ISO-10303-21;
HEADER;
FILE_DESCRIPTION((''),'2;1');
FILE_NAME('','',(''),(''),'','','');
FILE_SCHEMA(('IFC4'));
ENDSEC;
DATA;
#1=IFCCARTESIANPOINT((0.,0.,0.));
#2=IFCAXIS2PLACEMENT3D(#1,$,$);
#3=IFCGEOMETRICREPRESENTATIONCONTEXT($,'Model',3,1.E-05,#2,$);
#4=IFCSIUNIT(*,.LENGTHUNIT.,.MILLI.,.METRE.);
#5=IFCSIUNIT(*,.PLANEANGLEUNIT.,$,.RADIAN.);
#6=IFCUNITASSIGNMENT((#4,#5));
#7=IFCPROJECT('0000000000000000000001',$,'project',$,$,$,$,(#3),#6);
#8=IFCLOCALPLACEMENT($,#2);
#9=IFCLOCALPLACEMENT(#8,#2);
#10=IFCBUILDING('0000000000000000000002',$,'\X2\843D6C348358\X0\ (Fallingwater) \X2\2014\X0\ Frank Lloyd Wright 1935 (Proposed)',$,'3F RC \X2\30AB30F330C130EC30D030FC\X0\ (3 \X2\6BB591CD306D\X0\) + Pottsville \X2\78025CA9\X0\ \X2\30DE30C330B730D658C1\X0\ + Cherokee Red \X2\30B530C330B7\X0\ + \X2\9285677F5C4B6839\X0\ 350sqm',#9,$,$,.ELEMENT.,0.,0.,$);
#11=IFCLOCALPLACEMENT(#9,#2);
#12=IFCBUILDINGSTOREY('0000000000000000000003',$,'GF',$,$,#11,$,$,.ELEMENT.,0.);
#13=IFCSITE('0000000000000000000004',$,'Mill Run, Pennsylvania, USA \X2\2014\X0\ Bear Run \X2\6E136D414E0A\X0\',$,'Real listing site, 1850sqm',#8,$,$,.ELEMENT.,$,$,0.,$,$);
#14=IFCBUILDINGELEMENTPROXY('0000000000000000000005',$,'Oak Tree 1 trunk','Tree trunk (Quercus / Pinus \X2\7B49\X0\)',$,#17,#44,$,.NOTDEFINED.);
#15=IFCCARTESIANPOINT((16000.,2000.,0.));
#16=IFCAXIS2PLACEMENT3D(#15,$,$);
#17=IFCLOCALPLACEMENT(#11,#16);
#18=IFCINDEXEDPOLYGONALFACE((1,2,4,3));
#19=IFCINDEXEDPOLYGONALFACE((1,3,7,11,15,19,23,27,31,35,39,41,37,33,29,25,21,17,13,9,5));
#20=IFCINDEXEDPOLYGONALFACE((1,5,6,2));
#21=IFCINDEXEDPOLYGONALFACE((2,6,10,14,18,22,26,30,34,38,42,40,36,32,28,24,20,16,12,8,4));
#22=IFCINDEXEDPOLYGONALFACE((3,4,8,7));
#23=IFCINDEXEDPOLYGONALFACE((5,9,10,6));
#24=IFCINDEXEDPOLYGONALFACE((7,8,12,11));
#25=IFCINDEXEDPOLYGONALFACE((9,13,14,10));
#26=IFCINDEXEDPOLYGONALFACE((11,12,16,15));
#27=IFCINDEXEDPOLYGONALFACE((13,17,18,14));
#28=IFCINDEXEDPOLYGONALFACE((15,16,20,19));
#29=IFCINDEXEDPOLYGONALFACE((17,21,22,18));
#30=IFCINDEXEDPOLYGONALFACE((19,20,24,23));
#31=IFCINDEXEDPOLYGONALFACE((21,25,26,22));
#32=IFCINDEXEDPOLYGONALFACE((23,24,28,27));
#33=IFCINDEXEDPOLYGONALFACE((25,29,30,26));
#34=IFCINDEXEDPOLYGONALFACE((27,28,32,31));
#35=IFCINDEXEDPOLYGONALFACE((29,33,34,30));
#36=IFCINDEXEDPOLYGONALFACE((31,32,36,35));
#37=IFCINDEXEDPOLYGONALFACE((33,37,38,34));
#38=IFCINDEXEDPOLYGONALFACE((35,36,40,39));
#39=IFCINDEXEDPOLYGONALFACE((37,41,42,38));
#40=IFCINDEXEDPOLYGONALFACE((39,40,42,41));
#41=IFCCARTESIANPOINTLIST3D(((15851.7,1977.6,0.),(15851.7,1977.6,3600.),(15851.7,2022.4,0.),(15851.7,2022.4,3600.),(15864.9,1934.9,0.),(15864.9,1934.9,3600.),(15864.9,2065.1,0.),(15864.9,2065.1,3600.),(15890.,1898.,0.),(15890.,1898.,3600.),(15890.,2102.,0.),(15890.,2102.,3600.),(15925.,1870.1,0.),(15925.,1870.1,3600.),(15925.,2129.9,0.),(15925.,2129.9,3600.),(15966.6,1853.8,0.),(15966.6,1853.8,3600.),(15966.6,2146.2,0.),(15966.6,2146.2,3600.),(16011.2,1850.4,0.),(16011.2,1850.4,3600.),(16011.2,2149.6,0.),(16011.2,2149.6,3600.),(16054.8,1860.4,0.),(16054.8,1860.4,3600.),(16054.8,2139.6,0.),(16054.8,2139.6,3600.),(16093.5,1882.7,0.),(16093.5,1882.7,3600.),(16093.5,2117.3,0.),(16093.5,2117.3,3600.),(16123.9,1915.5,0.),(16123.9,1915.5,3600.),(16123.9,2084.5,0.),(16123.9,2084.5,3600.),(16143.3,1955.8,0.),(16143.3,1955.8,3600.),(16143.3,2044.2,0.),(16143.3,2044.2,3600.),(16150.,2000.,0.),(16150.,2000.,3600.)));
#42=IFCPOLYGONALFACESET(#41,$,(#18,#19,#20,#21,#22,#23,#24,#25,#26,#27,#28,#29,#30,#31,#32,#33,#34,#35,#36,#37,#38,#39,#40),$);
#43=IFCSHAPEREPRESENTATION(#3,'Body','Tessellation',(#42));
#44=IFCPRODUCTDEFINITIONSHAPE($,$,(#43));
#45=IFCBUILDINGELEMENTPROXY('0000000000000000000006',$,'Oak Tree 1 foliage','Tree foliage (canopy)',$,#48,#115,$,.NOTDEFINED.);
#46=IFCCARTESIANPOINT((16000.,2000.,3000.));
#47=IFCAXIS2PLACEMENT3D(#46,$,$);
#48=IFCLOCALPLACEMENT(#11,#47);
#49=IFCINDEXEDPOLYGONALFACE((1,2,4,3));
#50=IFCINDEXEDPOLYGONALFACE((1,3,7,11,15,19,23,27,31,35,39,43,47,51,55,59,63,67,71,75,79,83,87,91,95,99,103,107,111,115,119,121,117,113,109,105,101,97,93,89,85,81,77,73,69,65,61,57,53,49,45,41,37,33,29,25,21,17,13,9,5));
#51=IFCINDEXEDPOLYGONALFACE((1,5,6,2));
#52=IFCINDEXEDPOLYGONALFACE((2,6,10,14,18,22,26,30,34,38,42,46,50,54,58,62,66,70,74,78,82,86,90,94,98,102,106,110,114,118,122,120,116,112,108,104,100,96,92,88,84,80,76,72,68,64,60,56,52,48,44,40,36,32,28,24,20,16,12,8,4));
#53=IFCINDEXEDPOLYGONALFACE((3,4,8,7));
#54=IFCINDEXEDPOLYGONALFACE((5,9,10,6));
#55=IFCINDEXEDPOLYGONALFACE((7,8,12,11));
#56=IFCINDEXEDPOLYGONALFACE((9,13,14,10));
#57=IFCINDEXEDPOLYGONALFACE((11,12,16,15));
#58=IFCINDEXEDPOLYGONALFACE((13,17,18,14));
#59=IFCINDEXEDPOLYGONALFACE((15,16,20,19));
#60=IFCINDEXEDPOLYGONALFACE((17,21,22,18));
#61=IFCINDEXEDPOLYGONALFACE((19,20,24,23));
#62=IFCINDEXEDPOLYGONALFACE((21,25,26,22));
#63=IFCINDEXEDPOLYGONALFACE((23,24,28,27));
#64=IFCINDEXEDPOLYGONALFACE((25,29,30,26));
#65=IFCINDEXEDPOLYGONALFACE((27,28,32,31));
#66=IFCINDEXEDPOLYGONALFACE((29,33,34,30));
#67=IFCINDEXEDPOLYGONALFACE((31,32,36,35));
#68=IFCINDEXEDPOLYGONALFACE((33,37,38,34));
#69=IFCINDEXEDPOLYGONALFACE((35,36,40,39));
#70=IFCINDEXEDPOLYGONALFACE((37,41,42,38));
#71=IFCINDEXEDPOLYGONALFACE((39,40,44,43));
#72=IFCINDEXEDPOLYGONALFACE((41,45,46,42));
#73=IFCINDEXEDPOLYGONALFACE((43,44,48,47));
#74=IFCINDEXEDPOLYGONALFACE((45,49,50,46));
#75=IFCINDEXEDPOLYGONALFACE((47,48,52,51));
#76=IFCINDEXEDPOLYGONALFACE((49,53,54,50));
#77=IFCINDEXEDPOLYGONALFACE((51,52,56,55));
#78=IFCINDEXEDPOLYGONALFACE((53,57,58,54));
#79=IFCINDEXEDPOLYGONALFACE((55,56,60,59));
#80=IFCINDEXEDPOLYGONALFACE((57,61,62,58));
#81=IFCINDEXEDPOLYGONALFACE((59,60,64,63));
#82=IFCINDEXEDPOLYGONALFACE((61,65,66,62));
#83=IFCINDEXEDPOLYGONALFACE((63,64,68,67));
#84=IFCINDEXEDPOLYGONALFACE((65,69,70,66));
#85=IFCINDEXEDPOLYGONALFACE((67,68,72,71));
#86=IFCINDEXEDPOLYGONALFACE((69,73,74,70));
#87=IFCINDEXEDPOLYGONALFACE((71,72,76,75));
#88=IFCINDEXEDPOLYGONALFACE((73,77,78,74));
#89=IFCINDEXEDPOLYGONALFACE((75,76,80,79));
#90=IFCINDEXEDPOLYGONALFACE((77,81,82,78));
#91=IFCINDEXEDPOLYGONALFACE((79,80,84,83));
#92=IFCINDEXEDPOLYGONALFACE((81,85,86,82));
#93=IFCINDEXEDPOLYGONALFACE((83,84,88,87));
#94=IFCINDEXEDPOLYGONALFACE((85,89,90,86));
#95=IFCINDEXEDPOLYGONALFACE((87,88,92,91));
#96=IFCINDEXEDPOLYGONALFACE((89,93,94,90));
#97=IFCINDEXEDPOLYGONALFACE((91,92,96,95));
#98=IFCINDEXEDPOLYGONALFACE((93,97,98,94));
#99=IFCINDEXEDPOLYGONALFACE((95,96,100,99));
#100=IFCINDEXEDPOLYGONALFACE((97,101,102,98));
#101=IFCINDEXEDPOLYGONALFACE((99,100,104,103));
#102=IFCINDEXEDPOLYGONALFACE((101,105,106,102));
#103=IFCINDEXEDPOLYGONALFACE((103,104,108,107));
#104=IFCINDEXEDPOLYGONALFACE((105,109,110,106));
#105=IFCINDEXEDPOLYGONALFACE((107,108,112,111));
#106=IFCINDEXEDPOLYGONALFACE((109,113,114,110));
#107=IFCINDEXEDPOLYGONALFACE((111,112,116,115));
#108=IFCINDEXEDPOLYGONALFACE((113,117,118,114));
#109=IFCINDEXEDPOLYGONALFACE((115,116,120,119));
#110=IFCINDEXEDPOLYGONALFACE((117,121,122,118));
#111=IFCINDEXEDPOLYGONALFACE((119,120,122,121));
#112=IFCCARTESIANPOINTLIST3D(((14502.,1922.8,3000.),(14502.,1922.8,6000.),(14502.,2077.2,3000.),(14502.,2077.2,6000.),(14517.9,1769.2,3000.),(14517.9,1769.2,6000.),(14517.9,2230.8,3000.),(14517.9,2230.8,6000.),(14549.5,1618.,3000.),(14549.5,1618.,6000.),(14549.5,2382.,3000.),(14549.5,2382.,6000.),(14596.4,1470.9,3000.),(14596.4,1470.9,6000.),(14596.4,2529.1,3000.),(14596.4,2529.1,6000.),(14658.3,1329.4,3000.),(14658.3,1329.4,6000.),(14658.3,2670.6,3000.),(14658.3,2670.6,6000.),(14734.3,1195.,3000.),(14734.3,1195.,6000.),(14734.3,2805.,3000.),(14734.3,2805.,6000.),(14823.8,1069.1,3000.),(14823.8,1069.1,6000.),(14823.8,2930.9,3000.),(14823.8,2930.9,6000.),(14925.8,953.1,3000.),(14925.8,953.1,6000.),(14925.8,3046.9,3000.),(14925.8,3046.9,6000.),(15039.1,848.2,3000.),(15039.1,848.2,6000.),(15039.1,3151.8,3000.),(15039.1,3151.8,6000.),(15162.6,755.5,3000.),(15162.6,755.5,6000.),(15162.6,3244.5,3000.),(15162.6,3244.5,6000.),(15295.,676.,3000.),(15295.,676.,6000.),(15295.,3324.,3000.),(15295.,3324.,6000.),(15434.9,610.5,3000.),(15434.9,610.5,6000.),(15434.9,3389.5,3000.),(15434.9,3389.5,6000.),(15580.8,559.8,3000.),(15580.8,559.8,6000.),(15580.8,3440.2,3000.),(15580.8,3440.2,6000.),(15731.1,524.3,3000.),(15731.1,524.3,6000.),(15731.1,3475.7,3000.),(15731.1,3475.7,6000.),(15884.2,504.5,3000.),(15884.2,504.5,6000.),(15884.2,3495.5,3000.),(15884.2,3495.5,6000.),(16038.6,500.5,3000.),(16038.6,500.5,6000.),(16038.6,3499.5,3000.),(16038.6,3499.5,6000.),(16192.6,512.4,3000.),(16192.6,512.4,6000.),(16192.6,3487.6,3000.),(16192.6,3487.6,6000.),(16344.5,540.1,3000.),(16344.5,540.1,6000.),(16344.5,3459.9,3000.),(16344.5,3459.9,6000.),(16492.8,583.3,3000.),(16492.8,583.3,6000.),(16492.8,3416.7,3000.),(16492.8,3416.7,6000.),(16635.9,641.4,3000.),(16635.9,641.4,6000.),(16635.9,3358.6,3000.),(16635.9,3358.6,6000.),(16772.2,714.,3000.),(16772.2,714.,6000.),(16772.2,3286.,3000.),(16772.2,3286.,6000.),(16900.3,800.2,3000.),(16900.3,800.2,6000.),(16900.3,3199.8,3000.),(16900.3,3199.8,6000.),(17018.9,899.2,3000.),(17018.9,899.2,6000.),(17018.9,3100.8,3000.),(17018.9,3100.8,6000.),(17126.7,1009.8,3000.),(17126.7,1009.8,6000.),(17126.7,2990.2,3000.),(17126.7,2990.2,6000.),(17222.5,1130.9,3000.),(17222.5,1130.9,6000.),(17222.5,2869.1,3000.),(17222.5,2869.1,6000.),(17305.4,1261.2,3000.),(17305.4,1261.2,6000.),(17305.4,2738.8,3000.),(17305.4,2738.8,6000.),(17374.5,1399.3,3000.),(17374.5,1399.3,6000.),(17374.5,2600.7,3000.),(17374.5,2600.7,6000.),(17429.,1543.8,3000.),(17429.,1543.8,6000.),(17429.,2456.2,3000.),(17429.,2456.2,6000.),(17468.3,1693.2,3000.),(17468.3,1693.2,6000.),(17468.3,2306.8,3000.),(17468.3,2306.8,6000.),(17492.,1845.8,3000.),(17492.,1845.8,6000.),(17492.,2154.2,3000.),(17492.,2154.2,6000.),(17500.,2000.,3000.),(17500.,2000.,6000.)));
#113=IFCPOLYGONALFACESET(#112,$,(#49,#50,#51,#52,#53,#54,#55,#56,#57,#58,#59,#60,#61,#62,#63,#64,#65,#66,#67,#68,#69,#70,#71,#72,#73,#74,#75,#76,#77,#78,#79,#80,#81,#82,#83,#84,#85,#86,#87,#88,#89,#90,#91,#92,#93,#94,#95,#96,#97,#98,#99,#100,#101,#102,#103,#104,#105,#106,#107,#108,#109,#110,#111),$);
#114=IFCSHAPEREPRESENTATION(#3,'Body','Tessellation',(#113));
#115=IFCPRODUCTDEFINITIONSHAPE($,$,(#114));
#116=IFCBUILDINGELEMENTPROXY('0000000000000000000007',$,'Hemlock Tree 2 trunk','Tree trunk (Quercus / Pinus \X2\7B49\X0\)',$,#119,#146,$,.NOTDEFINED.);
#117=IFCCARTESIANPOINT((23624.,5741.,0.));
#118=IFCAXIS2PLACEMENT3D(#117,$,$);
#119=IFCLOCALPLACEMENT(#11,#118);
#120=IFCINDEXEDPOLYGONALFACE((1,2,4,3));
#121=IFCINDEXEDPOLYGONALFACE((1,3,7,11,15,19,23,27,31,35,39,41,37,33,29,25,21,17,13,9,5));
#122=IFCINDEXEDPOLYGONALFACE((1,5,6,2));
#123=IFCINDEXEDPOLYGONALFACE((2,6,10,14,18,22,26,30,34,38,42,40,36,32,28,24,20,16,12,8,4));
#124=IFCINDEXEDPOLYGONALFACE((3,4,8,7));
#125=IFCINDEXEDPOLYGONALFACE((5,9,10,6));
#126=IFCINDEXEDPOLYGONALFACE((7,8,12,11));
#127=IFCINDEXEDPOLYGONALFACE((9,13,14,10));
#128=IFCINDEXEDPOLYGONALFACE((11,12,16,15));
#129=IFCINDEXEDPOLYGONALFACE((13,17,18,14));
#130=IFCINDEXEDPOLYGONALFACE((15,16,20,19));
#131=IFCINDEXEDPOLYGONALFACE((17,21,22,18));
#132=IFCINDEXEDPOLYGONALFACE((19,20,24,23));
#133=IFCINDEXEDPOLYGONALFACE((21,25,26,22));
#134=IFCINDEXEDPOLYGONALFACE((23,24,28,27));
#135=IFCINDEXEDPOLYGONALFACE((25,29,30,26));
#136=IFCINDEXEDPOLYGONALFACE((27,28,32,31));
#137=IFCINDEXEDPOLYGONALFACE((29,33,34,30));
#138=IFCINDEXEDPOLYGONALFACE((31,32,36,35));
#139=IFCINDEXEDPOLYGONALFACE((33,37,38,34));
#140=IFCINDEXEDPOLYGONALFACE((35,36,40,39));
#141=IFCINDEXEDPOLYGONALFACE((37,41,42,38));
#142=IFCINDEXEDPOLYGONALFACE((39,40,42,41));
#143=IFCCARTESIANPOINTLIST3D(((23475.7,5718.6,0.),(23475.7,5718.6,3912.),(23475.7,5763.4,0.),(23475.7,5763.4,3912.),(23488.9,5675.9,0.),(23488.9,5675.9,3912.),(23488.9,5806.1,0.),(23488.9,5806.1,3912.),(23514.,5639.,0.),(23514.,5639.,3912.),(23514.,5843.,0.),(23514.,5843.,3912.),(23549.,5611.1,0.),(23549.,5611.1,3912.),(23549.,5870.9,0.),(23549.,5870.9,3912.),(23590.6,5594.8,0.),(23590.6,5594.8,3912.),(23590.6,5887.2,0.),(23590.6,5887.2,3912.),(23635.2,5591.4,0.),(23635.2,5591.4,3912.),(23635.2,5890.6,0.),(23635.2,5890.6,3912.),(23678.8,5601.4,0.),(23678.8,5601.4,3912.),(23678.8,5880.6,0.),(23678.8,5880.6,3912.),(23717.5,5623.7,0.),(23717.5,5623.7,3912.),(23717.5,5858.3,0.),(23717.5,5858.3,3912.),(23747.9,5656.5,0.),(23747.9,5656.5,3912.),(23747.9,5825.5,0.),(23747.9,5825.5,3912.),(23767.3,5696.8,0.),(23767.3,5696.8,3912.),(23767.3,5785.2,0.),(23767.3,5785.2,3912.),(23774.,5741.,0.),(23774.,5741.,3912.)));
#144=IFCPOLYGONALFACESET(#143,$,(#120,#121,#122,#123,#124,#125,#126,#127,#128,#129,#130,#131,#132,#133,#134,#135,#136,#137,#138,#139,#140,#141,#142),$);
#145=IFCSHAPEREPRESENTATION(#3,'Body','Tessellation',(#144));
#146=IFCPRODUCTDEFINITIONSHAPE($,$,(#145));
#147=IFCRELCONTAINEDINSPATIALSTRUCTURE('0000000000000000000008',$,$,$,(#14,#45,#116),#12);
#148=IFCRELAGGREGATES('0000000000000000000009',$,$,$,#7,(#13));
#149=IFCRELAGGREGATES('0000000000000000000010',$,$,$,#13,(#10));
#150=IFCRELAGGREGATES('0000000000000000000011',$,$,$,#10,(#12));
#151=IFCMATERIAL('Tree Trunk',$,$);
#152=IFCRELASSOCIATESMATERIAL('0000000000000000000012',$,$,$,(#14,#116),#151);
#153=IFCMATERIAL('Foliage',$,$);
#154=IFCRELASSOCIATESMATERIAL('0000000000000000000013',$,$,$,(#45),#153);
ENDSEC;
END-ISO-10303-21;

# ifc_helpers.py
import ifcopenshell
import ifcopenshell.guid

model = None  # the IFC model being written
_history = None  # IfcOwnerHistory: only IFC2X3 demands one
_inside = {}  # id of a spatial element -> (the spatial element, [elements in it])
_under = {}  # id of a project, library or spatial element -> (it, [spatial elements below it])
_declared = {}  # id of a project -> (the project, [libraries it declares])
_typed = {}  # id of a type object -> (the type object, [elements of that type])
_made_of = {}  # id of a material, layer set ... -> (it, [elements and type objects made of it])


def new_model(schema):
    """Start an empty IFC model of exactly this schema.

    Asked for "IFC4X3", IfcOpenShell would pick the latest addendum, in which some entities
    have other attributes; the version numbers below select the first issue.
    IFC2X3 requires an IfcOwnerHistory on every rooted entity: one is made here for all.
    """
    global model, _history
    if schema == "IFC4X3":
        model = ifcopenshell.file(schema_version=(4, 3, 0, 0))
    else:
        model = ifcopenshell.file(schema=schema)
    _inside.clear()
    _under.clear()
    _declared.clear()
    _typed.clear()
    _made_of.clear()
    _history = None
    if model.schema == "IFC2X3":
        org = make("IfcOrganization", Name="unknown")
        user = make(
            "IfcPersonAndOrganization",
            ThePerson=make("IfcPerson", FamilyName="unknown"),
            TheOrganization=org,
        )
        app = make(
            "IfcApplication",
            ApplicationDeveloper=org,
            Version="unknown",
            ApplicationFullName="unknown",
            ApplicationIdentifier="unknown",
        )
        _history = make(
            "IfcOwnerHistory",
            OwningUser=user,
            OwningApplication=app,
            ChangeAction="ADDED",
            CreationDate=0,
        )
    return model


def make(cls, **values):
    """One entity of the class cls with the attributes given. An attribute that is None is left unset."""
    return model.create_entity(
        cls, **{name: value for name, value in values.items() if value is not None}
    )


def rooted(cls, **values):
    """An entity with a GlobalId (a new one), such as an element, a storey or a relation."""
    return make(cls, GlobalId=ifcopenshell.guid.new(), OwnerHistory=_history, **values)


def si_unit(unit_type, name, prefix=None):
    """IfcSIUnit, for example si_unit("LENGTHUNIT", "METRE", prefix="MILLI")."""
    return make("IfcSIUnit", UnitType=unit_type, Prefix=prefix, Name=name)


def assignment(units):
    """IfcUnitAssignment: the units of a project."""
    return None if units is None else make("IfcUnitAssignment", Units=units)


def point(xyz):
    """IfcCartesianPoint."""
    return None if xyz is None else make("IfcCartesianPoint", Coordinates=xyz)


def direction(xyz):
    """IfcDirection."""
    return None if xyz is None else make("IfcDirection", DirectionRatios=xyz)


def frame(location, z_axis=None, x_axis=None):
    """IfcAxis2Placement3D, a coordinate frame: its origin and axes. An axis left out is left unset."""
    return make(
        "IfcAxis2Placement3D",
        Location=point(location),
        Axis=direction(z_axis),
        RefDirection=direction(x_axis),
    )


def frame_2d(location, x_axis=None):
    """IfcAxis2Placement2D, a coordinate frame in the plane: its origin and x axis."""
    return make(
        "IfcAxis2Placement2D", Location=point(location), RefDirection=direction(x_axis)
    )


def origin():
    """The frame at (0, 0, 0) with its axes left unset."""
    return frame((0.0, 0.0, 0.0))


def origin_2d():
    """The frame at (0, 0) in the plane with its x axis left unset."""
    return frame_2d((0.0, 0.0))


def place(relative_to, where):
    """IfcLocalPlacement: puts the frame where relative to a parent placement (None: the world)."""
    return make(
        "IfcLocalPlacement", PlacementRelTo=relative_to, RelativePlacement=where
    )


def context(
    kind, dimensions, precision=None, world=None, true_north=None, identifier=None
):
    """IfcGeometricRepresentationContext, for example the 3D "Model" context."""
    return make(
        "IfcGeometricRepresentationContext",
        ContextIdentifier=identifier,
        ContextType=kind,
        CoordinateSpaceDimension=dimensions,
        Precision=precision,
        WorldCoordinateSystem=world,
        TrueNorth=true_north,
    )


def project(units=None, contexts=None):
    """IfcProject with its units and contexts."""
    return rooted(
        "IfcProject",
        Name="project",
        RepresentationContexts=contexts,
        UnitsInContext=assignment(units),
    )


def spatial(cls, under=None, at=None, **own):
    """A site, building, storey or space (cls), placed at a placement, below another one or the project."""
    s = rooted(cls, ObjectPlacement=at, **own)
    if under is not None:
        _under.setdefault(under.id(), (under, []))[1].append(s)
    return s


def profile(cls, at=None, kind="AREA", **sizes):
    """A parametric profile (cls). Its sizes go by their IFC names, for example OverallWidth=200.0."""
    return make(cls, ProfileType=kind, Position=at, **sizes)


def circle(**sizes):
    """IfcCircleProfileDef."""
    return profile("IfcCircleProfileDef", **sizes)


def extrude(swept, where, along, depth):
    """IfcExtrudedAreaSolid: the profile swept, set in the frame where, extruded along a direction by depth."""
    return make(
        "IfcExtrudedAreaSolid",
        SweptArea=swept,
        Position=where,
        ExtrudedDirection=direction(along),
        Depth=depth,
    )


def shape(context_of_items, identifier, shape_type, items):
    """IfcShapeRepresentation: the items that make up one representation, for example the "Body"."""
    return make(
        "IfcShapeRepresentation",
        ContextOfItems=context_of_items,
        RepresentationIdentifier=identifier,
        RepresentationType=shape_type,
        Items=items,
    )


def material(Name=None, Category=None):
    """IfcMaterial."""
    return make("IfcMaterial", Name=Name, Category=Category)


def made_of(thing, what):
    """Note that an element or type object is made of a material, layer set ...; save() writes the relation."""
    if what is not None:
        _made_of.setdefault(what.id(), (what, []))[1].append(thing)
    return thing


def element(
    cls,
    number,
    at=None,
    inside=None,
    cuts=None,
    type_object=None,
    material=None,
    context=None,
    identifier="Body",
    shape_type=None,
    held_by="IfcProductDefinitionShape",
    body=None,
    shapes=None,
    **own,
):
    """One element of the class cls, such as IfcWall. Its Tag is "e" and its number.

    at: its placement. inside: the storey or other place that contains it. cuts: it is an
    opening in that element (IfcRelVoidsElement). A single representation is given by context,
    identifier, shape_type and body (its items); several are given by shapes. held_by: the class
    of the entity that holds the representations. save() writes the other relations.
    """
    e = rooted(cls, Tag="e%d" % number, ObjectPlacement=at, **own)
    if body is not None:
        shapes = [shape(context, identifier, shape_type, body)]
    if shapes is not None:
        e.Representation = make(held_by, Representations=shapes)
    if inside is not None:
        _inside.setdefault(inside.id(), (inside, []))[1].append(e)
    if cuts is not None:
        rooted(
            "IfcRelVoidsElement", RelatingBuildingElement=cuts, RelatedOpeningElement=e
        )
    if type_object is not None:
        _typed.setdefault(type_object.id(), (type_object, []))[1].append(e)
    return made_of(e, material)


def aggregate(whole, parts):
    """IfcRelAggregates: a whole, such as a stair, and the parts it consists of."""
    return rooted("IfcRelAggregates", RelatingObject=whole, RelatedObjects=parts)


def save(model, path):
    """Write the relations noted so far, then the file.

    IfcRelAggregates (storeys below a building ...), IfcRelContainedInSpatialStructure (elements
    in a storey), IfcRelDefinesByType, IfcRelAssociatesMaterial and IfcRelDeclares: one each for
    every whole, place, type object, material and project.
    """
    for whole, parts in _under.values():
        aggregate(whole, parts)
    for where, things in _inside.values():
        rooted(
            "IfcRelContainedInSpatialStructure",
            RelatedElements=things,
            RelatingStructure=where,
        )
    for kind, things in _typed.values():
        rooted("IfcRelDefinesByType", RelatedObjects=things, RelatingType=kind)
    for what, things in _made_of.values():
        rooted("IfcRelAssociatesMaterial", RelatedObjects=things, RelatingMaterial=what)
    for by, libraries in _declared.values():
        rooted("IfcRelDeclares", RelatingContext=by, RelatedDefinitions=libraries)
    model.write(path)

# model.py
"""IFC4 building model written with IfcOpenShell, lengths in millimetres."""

from ifc_helpers import new_model, si_unit, frame, origin, origin_2d, place, context, project, spatial, circle, extrude, material, element, save


model = new_model("IFC4")

# Units and contexts
model_context = context("Model", 3, precision=1e-05, world=origin())
ifc_project = project(units=[si_unit("LENGTHUNIT", "METRE", prefix="MILLI"), si_unit("PLANEANGLEUNIT", "RADIAN")], contexts=[model_context])

# Site, building, storey
site_placement = place(None, origin())
site = spatial("IfcSite", under=ifc_project, at=site_placement, Name="Mill Run, Pennsylvania, USA — Bear Run 渓流上", ObjectType="Real listing site, 1850sqm", CompositionType="ELEMENT", RefElevation=0.0)
building_placement = place(site_placement, origin())
building = spatial("IfcBuilding", under=site, at=building_placement, Name="落水荘 (Fallingwater) — Frank Lloyd Wright 1935 (Proposed)", ObjectType="3F RC カンチレバー (3 段重ね) + Pottsville 砂岩 マッシブ壁 + Cherokee Red サッシ + 銅板屋根 350sqm", CompositionType="ELEMENT", ElevationOfRefHeight=0.0, ElevationOfTerrain=0.0)
storey_placement = place(building_placement, origin())
storey = spatial("IfcBuildingStorey", under=building, at=storey_placement, Name="GF", CompositionType="ELEMENT", Elevation=0.0)

# Building element proxies
ifc_material_1 = material(Name="Tree Trunk")
proxy_1_placement = place(storey_placement, frame((16000.0, 2000.0, 0.0)))
element("IfcBuildingElementProxy", 1, at=proxy_1_placement, inside=storey, material=ifc_material_1, Name="Oak Tree 1 trunk", Description="Tree trunk (Quercus / Pinus 等)", PredefinedType="NOTDEFINED", context=model_context, shape_type="SweptSolid", body=[
    extrude(circle(Radius=150.0, at=origin_2d()), frame((16000.0, 2000.0, 0.0)), (0.0, 0.0, 1.0), 3600.0),
])
ifc_material_2 = material(Name="Foliage")
proxy_2_placement = place(storey_placement, frame((16000.0, 2000.0, 3000.0)))
element("IfcBuildingElementProxy", 2, at=proxy_2_placement, inside=storey, material=ifc_material_2, Name="Oak Tree 1 foliage", Description="Tree foliage (canopy)", PredefinedType="NOTDEFINED", context=model_context, shape_type="SweptSolid", body=[
    extrude(circle(Radius=1500.0, at=origin_2d()), frame((16000.0, 2000.0, 3000.0)), (0.0, 0.0, 1.0), 3000.0),
])
proxy_3_placement = place(storey_placement, frame((23624.0, 5741.0, 0.0)))
element("IfcBuildingElementProxy", 3, at=proxy_3_placement, inside=storey, material=ifc_material_1, Name="Hemlock Tree 2 trunk", Description="Tree trunk (Quercus / Pinus 等)", PredefinedType="NOTDEFINED", context=model_context, shape_type="SweptSolid", body=[
    extrude(circle(Radius=150.0, at=origin_2d()), frame((23624.0, 5741.0, 0.0)), (0.0, 0.0, 1.0), 3912.0),
])

save(model, "model.ifc")
